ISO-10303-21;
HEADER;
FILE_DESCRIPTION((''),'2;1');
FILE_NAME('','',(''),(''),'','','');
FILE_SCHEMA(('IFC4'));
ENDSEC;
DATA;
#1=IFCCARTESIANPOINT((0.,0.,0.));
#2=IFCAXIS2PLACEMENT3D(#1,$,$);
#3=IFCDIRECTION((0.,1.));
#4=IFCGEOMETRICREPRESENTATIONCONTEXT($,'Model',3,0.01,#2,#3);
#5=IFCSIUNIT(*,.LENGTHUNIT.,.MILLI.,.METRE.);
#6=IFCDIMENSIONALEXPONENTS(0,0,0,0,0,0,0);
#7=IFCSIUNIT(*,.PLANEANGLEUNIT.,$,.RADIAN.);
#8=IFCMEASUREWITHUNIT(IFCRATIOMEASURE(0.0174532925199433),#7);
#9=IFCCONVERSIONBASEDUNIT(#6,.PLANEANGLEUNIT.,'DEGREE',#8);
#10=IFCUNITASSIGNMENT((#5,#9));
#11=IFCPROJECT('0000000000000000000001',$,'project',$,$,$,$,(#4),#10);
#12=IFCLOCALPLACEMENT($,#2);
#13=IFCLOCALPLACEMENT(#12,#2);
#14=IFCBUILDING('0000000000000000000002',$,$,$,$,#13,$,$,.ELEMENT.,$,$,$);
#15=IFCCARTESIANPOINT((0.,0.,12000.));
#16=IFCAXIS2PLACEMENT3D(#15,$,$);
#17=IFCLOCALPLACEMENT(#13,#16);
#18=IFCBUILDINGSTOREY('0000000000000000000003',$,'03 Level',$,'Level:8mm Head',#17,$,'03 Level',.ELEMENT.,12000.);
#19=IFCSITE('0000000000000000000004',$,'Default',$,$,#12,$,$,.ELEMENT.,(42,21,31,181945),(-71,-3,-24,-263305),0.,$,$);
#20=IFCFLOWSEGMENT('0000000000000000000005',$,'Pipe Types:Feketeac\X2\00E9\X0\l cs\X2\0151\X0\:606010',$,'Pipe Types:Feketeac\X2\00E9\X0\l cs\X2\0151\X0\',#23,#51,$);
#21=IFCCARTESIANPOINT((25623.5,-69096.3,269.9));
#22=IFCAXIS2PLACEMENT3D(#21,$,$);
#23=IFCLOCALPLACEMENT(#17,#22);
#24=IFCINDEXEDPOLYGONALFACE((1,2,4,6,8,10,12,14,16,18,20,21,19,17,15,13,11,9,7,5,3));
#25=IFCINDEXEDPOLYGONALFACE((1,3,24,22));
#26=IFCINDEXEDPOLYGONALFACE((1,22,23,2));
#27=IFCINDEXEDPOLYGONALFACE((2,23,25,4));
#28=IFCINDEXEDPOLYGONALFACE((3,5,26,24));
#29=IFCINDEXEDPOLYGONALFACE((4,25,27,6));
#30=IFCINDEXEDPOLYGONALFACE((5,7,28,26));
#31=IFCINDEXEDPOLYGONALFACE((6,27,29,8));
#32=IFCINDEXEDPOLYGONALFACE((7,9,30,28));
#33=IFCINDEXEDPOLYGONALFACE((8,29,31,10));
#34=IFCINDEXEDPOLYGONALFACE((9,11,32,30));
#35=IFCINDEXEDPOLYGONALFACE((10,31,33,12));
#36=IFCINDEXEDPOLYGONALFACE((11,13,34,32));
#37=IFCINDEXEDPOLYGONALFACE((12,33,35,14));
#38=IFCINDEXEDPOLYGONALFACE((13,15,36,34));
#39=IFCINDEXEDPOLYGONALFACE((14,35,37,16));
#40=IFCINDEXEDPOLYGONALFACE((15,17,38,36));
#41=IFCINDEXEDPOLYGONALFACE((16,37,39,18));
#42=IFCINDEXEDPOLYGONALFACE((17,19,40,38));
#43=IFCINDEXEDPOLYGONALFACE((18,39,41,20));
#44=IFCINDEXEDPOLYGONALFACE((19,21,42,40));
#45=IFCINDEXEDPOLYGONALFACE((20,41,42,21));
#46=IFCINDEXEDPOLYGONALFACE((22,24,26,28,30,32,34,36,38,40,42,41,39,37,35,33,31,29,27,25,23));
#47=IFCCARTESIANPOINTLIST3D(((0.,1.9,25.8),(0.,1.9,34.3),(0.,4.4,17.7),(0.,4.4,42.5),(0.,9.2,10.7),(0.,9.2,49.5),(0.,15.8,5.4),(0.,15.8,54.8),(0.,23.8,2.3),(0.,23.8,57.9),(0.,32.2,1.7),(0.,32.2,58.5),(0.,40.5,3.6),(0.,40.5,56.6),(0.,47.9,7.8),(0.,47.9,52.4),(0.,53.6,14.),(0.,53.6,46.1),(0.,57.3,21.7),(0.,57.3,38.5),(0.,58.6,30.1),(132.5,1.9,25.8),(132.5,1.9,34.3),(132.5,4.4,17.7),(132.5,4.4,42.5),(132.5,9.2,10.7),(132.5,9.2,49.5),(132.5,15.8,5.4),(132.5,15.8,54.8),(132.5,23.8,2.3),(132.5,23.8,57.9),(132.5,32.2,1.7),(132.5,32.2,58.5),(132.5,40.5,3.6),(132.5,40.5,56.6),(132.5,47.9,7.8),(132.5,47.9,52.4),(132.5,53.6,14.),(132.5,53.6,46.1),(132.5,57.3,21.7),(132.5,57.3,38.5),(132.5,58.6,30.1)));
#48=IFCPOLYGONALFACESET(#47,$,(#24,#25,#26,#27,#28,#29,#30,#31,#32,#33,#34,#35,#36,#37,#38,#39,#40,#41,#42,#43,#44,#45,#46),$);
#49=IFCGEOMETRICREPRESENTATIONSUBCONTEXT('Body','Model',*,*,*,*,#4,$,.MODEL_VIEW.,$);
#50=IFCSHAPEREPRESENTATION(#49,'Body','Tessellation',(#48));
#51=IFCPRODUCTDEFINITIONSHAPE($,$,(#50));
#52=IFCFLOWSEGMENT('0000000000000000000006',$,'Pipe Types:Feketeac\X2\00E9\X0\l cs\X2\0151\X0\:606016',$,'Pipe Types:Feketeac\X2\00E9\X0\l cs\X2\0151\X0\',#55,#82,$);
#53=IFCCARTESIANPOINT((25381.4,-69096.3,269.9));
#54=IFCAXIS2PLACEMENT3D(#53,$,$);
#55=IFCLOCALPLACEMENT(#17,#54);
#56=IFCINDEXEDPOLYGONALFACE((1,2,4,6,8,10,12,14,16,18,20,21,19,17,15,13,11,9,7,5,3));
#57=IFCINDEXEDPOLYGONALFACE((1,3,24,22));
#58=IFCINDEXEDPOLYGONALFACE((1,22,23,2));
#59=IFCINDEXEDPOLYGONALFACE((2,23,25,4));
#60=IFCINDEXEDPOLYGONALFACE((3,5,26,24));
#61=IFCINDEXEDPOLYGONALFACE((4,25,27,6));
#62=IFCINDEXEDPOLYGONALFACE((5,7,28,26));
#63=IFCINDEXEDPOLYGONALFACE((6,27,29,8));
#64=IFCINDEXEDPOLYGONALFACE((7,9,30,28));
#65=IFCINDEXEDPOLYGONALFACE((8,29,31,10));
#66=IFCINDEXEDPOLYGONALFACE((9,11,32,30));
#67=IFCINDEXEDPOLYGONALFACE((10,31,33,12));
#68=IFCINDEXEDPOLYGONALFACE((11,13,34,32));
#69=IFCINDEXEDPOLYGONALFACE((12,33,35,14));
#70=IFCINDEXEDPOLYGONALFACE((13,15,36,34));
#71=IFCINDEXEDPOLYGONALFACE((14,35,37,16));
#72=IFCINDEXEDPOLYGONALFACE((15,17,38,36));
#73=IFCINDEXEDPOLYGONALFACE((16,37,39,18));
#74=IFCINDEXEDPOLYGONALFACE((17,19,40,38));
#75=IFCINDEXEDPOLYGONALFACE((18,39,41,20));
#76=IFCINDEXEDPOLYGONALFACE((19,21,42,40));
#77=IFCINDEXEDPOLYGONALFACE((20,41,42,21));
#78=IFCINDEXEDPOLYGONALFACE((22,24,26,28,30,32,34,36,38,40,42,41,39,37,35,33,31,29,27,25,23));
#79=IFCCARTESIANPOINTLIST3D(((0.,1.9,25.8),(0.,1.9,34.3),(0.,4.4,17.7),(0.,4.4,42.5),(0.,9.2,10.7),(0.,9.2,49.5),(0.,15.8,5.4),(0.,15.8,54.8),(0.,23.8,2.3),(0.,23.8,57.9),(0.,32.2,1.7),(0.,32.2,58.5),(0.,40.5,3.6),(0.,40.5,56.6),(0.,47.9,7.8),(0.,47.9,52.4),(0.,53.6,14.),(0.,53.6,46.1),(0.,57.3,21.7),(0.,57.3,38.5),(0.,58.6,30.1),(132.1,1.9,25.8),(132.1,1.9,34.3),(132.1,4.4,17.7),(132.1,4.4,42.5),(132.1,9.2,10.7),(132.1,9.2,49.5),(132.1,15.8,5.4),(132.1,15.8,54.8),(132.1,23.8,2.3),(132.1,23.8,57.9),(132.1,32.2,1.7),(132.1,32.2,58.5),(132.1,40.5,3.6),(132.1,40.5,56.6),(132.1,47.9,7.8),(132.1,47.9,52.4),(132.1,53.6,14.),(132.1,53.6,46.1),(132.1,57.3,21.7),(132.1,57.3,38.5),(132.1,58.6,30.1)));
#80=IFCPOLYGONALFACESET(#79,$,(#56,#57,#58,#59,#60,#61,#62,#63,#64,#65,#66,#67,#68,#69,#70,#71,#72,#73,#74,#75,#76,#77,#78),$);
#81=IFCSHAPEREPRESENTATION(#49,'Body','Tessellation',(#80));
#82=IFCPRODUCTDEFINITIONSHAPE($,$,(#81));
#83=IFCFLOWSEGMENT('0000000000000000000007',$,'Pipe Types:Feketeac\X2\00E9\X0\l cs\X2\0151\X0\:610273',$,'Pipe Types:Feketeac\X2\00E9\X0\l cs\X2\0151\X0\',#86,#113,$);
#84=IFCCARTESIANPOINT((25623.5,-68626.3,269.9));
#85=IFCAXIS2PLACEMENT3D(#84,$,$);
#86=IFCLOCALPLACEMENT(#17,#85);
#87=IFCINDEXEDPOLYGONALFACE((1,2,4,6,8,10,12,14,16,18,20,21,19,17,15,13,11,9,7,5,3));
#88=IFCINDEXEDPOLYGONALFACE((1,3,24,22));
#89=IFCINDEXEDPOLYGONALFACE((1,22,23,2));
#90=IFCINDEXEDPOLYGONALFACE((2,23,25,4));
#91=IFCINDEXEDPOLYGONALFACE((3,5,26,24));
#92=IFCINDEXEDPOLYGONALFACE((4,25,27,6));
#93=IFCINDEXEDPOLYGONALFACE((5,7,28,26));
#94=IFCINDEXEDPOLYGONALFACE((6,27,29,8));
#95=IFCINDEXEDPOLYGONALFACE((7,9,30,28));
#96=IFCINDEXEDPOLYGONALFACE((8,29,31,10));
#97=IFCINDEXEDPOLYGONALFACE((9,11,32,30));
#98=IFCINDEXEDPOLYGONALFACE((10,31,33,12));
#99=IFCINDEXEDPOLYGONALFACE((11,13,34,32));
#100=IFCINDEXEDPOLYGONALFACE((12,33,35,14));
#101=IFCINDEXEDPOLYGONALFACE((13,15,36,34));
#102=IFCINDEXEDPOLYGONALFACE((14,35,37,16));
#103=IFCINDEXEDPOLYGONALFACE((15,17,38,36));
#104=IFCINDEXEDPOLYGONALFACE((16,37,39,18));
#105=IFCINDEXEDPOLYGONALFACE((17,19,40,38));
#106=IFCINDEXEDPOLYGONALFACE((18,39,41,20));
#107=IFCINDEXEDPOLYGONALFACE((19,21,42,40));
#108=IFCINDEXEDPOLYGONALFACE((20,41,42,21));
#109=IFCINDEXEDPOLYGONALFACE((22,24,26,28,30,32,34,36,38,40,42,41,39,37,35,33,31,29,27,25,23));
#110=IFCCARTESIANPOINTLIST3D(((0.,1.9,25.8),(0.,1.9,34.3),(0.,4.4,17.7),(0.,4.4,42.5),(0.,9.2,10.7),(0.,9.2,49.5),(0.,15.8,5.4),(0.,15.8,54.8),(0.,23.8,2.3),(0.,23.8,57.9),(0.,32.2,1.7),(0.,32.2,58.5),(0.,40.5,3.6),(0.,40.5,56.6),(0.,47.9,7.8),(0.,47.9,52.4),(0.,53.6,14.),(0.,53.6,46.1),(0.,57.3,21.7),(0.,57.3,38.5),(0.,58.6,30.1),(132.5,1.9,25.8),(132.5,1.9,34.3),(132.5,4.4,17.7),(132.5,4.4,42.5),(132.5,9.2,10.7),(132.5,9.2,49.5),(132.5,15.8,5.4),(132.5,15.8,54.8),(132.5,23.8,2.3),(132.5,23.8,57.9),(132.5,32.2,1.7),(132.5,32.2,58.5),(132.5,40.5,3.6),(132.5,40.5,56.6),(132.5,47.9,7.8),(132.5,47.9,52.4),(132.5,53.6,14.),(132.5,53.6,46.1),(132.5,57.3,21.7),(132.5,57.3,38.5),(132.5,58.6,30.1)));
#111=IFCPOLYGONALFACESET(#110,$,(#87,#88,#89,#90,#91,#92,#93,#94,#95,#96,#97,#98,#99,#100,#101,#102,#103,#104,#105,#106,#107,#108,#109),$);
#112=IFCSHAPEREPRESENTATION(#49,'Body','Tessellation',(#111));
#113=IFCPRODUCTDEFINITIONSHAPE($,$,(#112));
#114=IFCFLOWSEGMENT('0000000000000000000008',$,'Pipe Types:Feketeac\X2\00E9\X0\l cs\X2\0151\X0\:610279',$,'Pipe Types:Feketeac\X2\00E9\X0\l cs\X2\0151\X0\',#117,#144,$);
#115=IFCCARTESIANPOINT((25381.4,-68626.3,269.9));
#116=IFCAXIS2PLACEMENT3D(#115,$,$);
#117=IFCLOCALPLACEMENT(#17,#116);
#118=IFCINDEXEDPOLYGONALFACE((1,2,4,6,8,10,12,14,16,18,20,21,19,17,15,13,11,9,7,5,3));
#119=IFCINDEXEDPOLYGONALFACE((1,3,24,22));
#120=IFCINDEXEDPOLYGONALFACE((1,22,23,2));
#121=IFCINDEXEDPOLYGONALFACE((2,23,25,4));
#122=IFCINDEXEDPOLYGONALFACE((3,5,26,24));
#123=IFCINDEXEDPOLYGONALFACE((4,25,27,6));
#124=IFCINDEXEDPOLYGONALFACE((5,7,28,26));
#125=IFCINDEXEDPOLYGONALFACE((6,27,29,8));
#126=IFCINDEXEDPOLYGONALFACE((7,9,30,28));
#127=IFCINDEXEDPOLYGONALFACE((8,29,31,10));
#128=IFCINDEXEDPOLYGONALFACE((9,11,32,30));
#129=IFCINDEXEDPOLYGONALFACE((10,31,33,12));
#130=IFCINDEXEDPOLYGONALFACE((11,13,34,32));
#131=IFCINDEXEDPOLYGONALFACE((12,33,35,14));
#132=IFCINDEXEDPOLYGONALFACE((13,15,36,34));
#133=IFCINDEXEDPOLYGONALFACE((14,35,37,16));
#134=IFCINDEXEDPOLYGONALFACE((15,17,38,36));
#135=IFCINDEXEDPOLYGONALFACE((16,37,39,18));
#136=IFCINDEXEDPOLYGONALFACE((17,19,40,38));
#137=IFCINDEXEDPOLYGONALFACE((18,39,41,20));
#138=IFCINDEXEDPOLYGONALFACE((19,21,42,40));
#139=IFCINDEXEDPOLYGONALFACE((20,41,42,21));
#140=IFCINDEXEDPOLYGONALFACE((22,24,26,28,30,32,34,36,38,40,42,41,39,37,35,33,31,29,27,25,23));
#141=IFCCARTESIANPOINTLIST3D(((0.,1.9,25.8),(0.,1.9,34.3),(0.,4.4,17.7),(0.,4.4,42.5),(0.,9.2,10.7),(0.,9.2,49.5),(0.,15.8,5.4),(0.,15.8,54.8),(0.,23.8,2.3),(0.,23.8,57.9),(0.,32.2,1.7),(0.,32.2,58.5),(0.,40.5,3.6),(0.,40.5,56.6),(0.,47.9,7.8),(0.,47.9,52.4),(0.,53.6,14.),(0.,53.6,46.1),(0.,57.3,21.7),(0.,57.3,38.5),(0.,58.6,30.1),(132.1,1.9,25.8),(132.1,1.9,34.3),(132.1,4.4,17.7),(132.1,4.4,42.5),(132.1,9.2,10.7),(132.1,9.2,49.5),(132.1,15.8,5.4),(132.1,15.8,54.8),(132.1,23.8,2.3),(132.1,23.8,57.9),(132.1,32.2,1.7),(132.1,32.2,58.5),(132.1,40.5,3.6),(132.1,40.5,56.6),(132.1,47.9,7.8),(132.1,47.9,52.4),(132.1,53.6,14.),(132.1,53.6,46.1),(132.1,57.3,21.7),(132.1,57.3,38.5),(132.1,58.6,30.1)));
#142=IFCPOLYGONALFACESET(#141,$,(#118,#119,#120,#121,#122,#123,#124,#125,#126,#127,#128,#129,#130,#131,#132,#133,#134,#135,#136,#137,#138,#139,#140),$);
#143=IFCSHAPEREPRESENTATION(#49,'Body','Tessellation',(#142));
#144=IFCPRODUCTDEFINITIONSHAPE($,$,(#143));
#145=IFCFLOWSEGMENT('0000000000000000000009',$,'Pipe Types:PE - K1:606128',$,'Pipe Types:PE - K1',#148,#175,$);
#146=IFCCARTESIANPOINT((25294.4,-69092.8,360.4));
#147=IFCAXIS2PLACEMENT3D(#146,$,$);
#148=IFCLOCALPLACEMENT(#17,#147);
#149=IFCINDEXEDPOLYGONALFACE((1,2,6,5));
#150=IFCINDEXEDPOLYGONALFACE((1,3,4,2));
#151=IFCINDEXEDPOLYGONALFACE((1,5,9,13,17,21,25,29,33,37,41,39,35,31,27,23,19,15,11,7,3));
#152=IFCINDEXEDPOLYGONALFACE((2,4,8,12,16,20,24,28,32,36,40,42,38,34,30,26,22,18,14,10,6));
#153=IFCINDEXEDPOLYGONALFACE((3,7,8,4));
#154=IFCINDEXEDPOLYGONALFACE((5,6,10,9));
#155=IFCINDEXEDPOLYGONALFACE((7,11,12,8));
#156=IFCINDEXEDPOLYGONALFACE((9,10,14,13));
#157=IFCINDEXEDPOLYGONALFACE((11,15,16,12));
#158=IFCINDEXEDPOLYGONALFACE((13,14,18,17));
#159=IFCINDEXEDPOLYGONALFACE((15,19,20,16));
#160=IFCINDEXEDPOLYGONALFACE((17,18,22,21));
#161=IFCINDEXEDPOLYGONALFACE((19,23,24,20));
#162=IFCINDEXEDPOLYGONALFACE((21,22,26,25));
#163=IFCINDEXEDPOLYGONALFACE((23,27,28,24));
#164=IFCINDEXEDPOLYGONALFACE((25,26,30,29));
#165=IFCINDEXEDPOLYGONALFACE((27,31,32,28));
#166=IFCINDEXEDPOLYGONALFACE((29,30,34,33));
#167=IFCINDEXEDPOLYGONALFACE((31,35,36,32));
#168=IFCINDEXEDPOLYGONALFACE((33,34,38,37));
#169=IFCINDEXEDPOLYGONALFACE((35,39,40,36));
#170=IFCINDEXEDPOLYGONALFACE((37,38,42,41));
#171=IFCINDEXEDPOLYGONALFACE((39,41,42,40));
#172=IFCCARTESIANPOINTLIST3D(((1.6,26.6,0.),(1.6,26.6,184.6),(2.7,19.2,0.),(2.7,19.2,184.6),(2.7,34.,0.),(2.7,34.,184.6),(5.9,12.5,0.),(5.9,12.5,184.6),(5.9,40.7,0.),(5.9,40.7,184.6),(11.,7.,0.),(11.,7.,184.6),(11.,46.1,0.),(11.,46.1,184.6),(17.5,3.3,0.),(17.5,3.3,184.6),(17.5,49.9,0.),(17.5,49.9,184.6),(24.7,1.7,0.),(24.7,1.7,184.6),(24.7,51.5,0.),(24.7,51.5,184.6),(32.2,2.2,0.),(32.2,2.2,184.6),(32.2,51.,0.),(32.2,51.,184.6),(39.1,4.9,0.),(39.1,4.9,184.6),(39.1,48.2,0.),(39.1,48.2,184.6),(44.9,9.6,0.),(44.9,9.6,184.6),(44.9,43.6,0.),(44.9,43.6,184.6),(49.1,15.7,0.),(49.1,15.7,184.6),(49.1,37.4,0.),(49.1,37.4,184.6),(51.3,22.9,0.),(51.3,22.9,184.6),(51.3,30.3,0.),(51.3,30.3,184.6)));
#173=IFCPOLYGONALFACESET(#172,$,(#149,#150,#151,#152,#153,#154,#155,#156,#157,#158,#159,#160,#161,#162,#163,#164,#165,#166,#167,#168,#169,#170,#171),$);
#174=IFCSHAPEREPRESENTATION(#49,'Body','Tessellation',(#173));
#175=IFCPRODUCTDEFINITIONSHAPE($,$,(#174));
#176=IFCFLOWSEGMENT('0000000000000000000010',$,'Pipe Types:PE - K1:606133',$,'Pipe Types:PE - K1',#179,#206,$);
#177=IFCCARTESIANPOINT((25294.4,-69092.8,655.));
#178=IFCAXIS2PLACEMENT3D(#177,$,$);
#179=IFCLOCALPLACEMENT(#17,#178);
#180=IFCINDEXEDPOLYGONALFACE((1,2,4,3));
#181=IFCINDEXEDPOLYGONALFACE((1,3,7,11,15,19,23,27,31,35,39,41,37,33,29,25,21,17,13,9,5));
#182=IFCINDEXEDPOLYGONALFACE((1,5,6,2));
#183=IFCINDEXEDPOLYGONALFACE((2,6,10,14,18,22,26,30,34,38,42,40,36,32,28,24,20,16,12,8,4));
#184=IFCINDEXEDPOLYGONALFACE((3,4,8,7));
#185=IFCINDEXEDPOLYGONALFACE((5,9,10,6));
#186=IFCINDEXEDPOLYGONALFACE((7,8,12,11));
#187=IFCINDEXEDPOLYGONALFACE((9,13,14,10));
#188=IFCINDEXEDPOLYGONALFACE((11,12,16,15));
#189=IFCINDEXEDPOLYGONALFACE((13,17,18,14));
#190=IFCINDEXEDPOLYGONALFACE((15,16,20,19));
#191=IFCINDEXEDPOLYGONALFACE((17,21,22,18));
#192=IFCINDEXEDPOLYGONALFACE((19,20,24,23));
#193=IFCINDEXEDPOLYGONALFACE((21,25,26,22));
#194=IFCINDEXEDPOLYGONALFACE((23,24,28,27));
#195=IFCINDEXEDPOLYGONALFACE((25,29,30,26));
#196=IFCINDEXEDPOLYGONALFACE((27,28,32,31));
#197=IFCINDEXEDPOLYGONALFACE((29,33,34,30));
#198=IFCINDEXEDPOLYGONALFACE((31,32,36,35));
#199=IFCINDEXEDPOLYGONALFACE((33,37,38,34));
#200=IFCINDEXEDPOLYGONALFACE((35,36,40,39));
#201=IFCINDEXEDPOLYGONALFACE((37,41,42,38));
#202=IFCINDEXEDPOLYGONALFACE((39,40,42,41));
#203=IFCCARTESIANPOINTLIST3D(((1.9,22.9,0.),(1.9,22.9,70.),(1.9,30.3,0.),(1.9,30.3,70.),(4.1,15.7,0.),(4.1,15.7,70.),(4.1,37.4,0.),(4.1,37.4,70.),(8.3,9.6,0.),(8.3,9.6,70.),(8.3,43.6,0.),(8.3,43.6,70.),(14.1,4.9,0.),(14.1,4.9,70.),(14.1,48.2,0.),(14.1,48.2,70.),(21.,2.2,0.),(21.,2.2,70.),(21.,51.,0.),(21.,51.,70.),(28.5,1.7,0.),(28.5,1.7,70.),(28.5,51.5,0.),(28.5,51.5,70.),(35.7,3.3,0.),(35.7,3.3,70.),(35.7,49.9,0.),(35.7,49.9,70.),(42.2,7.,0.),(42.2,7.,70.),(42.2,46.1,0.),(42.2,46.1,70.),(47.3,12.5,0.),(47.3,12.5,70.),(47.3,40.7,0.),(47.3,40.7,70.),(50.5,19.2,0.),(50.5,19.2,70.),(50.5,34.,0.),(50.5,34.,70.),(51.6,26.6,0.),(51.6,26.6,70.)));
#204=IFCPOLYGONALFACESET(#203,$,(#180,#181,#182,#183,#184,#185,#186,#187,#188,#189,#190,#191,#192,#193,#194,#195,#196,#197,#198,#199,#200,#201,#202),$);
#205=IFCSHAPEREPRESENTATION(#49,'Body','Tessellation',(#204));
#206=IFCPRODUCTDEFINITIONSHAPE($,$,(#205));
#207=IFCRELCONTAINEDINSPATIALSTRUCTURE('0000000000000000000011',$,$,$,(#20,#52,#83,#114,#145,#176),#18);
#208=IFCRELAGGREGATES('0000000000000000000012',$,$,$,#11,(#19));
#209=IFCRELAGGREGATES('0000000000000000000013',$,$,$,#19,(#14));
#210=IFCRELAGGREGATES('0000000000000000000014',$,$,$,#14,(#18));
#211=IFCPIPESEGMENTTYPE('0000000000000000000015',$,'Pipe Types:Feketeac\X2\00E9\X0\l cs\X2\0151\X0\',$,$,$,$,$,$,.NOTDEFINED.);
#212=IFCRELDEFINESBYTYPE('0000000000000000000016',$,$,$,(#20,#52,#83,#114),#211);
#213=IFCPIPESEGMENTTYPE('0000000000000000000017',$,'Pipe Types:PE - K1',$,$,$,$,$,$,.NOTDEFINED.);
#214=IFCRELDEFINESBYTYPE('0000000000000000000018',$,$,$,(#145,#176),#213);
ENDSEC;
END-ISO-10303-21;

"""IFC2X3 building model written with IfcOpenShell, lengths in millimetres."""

from ifc_helpers import new_model, entity, si_unit, converted_unit, direction, frame, frame_2d, origin, origin_2d_with_axis, place, context, subcontext, project, spatial, circle, extrude, type_object, element, save


model = new_model("IFC2X3")

# Units and contexts
model_context = context("Model", 3, precision=0.01, world=origin(), true_north=direction((0.0, 1.0)))
body_context = subcontext(model_context, "Body", "Model", "MODEL_VIEW")
ifc_project = project(units=[si_unit("LENGTHUNIT", "METRE", prefix="MILLI"), converted_unit("PLANEANGLEUNIT", "DEGREE", entity("IfcRatioMeasure", 0.0174532925199433), si_unit("PLANEANGLEUNIT", "RADIAN"), dimensions=[0, 0, 0, 0, 0, 0, 0])], contexts=[model_context])

# Site, building, storey
site_placement = place(None, origin())
site = spatial("IfcSite", under=ifc_project, at=site_placement, Name="Default", CompositionType="ELEMENT", RefLatitude=(42, 21, 31, 181945), RefLongitude=(-71, -3, -24, -263305), RefElevation=0.0)
building_placement = place(site_placement, origin())
building = spatial("IfcBuilding", under=site, at=building_placement, CompositionType="ELEMENT")
storey_placement = place(building_placement, frame((0.0, 0.0, 12000.0)))
storey = spatial("IfcBuildingStorey", under=building, at=storey_placement, Name="03 Level", ObjectType="Level:8mm Head", LongName="03 Level", CompositionType="ELEMENT", Elevation=12000.0)

# Flow segments
pipe_segment_type_1 = type_object("IfcPipeSegmentType", Name="Pipe Types:Feketeacél cső", PredefinedType="NOTDEFINED")
flow_segment_1_placement = place(storey_placement, frame((25623.5, -69096.3, 269.9)))
element("IfcFlowSegment", 1, at=flow_segment_1_placement, inside=storey, type_object=pipe_segment_type_1, Name="Pipe Types:Feketeacél cső:606010", ObjectType="Pipe Types:Feketeacél cső", context=body_context, shape_type="SweptSolid", body=[
    extrude(circle(Radius=28.5, at=origin_2d_with_axis()), frame((0.0, 30.1, 30.1), z_axis=(1.0, 0.0, 0.0), x_axis=(0.0, 1.0, 0.0)), (0.0, 0.0, 1.0), 132.5),
])
flow_segment_2_placement = place(storey_placement, frame((25381.4, -69096.3, 269.9)))
element("IfcFlowSegment", 2, at=flow_segment_2_placement, inside=storey, type_object=pipe_segment_type_1, Name="Pipe Types:Feketeacél cső:606016", ObjectType="Pipe Types:Feketeacél cső", context=body_context, shape_type="SweptSolid", body=[
    extrude(circle(Radius=28.5, at=origin_2d_with_axis()), frame((0.0, 30.1, 30.1), z_axis=(1.0, 0.0, 0.0), x_axis=(0.0, 1.0, 0.0)), (0.0, 0.0, 1.0), 132.1),
])
flow_segment_3_placement = place(storey_placement, frame((25623.5, -68626.3, 269.9)))
element("IfcFlowSegment", 3, at=flow_segment_3_placement, inside=storey, type_object=pipe_segment_type_1, Name="Pipe Types:Feketeacél cső:610273", ObjectType="Pipe Types:Feketeacél cső", context=body_context, shape_type="SweptSolid", body=[
    extrude(circle(Radius=28.5, at=origin_2d_with_axis()), frame((0.0, 30.1, 30.1), z_axis=(1.0, 0.0, 0.0), x_axis=(0.0, 1.0, 0.0)), (0.0, 0.0, 1.0), 132.5),
])
flow_segment_4_placement = place(storey_placement, frame((25381.4, -68626.3, 269.9)))
element("IfcFlowSegment", 4, at=flow_segment_4_placement, inside=storey, type_object=pipe_segment_type_1, Name="Pipe Types:Feketeacél cső:610279", ObjectType="Pipe Types:Feketeacél cső", context=body_context, shape_type="SweptSolid", body=[
    extrude(circle(Radius=28.5, at=origin_2d_with_axis()), frame((0.0, 30.1, 30.1), z_axis=(1.0, 0.0, 0.0), x_axis=(0.0, 1.0, 0.0)), (0.0, 0.0, 1.0), 132.1),
])
pipe_segment_type_2 = type_object("IfcPipeSegmentType", Name="Pipe Types:PE - K1", PredefinedType="NOTDEFINED")
flow_segment_5_placement = place(storey_placement, frame((25294.4, -69092.8, 360.4)))
element("IfcFlowSegment", 5, at=flow_segment_5_placement, inside=storey, type_object=pipe_segment_type_2, Name="Pipe Types:PE - K1:606128", ObjectType="Pipe Types:PE - K1", context=body_context, shape_type="SweptSolid", body=[
    extrude(circle(Radius=25.0, at=origin_2d_with_axis()), frame((26.6, 26.6, 0.0), z_axis=(0.0, 0.0, 1.0), x_axis=(-1.0, 0.0, 0.0)), (0.0, 0.0, 1.0), 184.6),
])
flow_segment_6_placement = place(storey_placement, frame((25294.4, -69092.8, 655.0)))
element("IfcFlowSegment", 6, at=flow_segment_6_placement, inside=storey, type_object=pipe_segment_type_2, Name="Pipe Types:PE - K1:606133", ObjectType="Pipe Types:PE - K1", context=body_context, shape_type="SweptSolid", body=[
    extrude(circle(Radius=25.0, at=frame_2d((0.0, 0.0), x_axis=(1.0, 0.0))), frame((26.6, 26.6, 0.0)), (0.0, 0.0, 1.0), 70.0),
])

save(model, "model.ifc")
